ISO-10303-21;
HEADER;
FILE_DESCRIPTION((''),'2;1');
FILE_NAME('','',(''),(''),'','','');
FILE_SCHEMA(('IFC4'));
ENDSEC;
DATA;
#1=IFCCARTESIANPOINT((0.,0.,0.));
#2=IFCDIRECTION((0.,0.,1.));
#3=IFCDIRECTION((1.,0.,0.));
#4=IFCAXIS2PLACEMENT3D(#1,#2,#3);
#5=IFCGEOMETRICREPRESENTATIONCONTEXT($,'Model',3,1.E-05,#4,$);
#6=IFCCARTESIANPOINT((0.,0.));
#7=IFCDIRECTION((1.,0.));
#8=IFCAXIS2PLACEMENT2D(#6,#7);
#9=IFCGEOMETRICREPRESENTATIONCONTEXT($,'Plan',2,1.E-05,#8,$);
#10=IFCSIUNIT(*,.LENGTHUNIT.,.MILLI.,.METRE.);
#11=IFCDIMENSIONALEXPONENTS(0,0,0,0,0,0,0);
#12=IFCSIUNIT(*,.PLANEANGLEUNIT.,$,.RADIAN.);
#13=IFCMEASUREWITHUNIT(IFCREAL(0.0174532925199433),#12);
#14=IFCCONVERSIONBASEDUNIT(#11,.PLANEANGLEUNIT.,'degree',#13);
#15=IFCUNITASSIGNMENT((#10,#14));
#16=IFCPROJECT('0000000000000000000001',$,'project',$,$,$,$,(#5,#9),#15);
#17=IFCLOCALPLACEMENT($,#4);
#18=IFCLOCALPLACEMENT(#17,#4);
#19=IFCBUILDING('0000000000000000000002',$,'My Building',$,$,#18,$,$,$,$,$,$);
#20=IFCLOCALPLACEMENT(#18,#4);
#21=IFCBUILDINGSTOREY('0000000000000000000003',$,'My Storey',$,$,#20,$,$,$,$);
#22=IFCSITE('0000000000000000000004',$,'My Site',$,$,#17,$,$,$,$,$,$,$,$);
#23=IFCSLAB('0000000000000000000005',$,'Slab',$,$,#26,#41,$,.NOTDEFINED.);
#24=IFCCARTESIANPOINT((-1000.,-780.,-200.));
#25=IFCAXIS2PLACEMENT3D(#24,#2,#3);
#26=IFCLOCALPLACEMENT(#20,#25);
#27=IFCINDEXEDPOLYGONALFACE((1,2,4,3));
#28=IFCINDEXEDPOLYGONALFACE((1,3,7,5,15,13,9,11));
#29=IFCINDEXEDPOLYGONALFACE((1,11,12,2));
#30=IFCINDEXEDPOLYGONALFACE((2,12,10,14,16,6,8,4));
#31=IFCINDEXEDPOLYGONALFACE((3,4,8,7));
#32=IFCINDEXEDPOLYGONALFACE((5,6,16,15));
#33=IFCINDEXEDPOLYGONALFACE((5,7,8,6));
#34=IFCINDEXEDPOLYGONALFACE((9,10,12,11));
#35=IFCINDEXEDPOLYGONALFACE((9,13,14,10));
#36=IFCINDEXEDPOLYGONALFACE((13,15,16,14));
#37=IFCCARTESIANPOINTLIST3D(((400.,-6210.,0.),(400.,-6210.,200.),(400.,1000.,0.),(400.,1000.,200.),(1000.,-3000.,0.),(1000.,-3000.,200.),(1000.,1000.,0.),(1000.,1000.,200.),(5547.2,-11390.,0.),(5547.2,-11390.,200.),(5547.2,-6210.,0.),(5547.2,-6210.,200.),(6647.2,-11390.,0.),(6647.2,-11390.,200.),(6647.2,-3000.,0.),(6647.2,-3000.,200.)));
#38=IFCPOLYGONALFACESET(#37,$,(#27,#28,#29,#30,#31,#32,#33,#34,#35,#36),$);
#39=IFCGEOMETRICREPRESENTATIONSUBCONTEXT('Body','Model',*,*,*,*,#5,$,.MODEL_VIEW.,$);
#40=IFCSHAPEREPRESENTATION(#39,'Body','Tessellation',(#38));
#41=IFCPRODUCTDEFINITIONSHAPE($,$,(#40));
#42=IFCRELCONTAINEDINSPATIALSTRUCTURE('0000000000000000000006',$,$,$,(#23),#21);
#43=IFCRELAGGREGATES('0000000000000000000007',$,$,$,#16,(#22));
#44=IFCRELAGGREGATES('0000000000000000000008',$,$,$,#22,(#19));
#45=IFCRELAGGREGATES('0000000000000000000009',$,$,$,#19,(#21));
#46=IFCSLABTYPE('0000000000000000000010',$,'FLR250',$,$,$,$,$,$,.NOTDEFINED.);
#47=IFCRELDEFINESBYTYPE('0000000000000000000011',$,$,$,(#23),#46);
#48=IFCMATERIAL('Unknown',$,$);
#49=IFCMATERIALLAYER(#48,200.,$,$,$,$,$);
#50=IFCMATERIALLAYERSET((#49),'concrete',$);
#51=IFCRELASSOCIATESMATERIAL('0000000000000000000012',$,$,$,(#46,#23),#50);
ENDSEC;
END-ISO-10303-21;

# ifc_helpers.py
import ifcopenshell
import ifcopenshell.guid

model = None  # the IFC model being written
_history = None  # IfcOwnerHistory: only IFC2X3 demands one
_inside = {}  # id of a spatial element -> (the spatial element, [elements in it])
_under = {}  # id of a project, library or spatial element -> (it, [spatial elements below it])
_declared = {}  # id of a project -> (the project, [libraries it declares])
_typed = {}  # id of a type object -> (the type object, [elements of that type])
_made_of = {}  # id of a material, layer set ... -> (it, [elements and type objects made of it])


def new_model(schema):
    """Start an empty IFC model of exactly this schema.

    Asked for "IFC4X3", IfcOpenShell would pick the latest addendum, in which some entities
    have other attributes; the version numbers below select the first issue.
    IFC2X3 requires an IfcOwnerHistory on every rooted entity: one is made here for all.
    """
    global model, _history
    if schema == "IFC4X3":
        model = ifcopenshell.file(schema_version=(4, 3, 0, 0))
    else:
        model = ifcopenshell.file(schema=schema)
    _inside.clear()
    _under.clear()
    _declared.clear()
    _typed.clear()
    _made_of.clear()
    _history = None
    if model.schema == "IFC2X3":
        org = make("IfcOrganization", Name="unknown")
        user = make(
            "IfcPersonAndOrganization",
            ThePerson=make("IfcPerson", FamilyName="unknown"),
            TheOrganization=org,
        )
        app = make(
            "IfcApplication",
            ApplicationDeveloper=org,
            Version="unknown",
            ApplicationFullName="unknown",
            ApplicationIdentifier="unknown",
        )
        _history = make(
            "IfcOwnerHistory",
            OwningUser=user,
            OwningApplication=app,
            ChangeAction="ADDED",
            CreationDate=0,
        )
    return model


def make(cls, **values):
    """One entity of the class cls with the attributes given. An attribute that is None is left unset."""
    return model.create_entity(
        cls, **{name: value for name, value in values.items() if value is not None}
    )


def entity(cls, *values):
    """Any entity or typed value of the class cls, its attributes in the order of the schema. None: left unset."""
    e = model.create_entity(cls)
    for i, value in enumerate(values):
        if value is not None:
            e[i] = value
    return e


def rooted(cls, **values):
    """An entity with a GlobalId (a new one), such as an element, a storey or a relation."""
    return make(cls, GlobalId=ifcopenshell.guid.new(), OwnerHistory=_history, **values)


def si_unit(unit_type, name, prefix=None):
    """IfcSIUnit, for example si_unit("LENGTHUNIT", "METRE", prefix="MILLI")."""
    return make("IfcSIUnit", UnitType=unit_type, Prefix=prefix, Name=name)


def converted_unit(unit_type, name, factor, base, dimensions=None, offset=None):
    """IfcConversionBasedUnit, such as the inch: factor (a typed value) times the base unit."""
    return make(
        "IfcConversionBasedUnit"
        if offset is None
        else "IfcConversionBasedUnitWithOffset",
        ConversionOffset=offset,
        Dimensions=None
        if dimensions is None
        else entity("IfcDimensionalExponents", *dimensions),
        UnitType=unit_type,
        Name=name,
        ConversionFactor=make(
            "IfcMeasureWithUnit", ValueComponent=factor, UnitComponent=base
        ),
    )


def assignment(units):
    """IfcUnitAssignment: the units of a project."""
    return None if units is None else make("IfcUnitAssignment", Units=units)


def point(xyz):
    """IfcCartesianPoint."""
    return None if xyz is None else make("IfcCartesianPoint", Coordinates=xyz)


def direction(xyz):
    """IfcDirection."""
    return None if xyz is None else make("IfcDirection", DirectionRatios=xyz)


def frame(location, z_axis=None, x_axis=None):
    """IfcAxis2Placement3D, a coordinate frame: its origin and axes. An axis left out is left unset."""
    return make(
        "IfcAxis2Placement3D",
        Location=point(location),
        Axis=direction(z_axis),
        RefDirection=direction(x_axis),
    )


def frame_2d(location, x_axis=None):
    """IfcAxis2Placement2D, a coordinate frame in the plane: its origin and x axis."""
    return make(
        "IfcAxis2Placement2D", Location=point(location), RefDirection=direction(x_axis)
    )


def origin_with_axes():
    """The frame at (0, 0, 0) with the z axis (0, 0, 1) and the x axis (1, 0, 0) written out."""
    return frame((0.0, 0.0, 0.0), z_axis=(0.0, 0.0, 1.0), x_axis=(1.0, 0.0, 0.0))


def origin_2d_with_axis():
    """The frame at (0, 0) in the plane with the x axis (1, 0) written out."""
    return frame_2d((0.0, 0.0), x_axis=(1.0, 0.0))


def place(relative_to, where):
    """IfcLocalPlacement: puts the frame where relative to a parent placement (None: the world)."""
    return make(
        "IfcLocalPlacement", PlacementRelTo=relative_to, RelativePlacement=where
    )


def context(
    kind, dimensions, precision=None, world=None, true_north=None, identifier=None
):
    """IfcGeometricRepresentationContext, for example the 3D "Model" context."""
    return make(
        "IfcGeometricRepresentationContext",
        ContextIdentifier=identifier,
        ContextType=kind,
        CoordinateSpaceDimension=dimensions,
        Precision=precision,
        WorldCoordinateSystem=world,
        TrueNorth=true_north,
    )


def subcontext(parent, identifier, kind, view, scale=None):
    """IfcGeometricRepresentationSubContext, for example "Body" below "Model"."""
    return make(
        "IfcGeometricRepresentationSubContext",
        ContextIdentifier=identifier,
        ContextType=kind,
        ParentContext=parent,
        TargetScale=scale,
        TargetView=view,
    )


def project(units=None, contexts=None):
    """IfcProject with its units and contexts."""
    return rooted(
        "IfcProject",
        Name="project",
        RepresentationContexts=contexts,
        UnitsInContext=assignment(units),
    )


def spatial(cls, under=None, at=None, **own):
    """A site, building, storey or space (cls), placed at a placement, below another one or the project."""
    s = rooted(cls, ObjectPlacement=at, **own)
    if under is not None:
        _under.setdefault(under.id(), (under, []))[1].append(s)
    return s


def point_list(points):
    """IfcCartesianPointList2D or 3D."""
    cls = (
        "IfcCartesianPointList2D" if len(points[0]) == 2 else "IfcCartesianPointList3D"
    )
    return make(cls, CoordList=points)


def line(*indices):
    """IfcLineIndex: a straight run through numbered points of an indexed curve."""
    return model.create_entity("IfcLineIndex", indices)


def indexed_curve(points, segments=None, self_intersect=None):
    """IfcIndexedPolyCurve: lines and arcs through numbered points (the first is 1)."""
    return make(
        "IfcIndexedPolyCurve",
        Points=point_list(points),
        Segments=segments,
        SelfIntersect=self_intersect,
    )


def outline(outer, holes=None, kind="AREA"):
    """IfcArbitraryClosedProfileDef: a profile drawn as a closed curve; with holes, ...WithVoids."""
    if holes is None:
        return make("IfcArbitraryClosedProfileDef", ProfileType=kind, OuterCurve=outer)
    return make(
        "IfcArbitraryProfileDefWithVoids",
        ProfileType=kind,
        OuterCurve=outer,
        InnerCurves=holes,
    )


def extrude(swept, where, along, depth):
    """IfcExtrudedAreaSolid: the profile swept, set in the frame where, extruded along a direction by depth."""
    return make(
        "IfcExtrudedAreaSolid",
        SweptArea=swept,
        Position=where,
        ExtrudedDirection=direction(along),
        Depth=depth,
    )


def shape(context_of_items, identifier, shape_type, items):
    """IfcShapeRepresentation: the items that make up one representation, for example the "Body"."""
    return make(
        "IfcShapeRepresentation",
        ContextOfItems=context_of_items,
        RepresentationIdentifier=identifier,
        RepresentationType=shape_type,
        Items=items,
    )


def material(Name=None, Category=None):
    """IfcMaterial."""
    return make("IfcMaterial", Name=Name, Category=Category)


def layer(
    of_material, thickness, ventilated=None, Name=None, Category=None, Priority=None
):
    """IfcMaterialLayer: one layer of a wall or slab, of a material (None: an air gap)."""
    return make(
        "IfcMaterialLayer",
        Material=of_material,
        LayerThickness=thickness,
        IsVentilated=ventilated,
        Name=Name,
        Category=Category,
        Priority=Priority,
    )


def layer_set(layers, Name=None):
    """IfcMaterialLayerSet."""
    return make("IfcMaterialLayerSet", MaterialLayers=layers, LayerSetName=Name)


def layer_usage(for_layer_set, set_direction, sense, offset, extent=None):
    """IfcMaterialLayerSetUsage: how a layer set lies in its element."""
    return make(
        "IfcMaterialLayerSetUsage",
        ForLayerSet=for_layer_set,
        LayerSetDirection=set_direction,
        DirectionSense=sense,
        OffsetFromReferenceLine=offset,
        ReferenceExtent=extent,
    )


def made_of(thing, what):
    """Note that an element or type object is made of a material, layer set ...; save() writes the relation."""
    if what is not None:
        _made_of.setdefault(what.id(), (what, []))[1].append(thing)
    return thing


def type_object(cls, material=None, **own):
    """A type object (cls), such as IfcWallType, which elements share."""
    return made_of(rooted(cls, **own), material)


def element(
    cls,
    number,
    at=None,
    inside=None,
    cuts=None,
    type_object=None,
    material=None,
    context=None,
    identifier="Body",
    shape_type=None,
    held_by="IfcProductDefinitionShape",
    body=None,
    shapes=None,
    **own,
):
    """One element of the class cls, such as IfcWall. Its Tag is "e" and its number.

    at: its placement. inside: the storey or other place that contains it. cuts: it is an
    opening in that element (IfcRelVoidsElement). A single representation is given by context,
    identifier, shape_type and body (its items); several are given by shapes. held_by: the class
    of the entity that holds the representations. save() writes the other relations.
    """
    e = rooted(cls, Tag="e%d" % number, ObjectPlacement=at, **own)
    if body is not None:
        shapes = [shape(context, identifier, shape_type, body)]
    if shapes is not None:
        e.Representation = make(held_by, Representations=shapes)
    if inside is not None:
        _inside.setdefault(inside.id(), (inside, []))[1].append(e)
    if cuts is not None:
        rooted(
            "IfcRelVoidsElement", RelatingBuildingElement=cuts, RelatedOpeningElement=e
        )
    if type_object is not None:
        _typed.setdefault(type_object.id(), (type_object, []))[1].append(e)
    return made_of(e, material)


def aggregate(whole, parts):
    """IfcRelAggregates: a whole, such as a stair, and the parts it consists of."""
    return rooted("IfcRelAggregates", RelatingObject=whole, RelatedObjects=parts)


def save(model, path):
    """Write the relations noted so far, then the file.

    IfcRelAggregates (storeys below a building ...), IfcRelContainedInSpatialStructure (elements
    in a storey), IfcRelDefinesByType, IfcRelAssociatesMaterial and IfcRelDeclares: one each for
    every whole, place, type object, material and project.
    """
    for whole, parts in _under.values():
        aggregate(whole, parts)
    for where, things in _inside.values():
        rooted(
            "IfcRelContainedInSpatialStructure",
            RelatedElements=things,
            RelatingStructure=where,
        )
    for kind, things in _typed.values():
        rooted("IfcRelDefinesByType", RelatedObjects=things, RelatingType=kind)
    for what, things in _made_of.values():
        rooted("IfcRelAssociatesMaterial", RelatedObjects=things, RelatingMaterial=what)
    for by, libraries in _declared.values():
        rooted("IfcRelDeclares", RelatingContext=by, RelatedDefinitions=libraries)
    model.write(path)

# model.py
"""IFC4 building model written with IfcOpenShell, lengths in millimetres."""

from ifc_helpers import new_model, entity, si_unit, converted_unit, frame, origin_with_axes, origin_2d_with_axis, place, context, subcontext, project, spatial, line, indexed_curve, outline, extrude, material, layer, layer_set, layer_usage, type_object, element, save


model = new_model("IFC4")

# Units and contexts
model_context = context("Model", 3, precision=1e-05, world=origin_with_axes())
plan_context = context("Plan", 2, precision=1e-05, world=origin_2d_with_axis())
body_context_1 = subcontext(model_context, "Body", "Model", "MODEL_VIEW")
ifc_project = project(units=[si_unit("LENGTHUNIT", "METRE", prefix="MILLI"), converted_unit("PLANEANGLEUNIT", "degree", entity("IfcReal", 0.0174532925199433), si_unit("PLANEANGLEUNIT", "RADIAN"), dimensions=[0, 0, 0, 0, 0, 0, 0])], contexts=[model_context, plan_context])

# Site, building, storey
site_placement = place(None, origin_with_axes())
site = spatial("IfcSite", under=ifc_project, at=site_placement, Name="My Site")
building_placement = place(site_placement, origin_with_axes())
building = spatial("IfcBuilding", under=site, at=building_placement, Name="My Building")
storey_placement = place(building_placement, origin_with_axes())
storey = spatial("IfcBuildingStorey", under=building, at=storey_placement, Name="My Storey")

# Slab
ifc_material_1 = material(Name="Unknown")
ifc_layer_1 = layer(ifc_material_1, 200.0)
ifc_layer_set_1 = layer_set([ifc_layer_1], Name="concrete")
ifc_layer_usage_1 = layer_usage(ifc_layer_set_1, "AXIS3", "POSITIVE", 0.0)
slab_type = type_object("IfcSlabType", Name="FLR250", PredefinedType="NOTDEFINED", material=ifc_layer_set_1)
slab_1_placement = place(storey_placement, frame((-1000.0, -780.0, -200.0), z_axis=(0.0, 0.0, 1.0), x_axis=(1.0, 0.0, 0.0)))
element("IfcSlab", 1, at=slab_1_placement, inside=storey, type_object=slab_type, material=ifc_layer_usage_1, Name="Slab", PredefinedType="NOTDEFINED", context=body_context_1, shape_type="SweptSolid", body=[
    extrude(outline(indexed_curve([(400.0, -6210.0), (5547.2, -6210.0), (1000.0, 1000.0), (400.0, 1000.0), (1000.0, -3000.0), (6647.2, -3000.0), (5547.2, -11390.0), (6647.2, -11390.0)], segments=[line(5, 6), line(6, 8), line(8, 7), line(7, 2), line(2, 1), line(1, 4), line(4, 3), line(3, 5)], self_intersect=False)), None, (0.0, 0.0, 1.0), 200.0),
])

save(model, "model.ifc")
